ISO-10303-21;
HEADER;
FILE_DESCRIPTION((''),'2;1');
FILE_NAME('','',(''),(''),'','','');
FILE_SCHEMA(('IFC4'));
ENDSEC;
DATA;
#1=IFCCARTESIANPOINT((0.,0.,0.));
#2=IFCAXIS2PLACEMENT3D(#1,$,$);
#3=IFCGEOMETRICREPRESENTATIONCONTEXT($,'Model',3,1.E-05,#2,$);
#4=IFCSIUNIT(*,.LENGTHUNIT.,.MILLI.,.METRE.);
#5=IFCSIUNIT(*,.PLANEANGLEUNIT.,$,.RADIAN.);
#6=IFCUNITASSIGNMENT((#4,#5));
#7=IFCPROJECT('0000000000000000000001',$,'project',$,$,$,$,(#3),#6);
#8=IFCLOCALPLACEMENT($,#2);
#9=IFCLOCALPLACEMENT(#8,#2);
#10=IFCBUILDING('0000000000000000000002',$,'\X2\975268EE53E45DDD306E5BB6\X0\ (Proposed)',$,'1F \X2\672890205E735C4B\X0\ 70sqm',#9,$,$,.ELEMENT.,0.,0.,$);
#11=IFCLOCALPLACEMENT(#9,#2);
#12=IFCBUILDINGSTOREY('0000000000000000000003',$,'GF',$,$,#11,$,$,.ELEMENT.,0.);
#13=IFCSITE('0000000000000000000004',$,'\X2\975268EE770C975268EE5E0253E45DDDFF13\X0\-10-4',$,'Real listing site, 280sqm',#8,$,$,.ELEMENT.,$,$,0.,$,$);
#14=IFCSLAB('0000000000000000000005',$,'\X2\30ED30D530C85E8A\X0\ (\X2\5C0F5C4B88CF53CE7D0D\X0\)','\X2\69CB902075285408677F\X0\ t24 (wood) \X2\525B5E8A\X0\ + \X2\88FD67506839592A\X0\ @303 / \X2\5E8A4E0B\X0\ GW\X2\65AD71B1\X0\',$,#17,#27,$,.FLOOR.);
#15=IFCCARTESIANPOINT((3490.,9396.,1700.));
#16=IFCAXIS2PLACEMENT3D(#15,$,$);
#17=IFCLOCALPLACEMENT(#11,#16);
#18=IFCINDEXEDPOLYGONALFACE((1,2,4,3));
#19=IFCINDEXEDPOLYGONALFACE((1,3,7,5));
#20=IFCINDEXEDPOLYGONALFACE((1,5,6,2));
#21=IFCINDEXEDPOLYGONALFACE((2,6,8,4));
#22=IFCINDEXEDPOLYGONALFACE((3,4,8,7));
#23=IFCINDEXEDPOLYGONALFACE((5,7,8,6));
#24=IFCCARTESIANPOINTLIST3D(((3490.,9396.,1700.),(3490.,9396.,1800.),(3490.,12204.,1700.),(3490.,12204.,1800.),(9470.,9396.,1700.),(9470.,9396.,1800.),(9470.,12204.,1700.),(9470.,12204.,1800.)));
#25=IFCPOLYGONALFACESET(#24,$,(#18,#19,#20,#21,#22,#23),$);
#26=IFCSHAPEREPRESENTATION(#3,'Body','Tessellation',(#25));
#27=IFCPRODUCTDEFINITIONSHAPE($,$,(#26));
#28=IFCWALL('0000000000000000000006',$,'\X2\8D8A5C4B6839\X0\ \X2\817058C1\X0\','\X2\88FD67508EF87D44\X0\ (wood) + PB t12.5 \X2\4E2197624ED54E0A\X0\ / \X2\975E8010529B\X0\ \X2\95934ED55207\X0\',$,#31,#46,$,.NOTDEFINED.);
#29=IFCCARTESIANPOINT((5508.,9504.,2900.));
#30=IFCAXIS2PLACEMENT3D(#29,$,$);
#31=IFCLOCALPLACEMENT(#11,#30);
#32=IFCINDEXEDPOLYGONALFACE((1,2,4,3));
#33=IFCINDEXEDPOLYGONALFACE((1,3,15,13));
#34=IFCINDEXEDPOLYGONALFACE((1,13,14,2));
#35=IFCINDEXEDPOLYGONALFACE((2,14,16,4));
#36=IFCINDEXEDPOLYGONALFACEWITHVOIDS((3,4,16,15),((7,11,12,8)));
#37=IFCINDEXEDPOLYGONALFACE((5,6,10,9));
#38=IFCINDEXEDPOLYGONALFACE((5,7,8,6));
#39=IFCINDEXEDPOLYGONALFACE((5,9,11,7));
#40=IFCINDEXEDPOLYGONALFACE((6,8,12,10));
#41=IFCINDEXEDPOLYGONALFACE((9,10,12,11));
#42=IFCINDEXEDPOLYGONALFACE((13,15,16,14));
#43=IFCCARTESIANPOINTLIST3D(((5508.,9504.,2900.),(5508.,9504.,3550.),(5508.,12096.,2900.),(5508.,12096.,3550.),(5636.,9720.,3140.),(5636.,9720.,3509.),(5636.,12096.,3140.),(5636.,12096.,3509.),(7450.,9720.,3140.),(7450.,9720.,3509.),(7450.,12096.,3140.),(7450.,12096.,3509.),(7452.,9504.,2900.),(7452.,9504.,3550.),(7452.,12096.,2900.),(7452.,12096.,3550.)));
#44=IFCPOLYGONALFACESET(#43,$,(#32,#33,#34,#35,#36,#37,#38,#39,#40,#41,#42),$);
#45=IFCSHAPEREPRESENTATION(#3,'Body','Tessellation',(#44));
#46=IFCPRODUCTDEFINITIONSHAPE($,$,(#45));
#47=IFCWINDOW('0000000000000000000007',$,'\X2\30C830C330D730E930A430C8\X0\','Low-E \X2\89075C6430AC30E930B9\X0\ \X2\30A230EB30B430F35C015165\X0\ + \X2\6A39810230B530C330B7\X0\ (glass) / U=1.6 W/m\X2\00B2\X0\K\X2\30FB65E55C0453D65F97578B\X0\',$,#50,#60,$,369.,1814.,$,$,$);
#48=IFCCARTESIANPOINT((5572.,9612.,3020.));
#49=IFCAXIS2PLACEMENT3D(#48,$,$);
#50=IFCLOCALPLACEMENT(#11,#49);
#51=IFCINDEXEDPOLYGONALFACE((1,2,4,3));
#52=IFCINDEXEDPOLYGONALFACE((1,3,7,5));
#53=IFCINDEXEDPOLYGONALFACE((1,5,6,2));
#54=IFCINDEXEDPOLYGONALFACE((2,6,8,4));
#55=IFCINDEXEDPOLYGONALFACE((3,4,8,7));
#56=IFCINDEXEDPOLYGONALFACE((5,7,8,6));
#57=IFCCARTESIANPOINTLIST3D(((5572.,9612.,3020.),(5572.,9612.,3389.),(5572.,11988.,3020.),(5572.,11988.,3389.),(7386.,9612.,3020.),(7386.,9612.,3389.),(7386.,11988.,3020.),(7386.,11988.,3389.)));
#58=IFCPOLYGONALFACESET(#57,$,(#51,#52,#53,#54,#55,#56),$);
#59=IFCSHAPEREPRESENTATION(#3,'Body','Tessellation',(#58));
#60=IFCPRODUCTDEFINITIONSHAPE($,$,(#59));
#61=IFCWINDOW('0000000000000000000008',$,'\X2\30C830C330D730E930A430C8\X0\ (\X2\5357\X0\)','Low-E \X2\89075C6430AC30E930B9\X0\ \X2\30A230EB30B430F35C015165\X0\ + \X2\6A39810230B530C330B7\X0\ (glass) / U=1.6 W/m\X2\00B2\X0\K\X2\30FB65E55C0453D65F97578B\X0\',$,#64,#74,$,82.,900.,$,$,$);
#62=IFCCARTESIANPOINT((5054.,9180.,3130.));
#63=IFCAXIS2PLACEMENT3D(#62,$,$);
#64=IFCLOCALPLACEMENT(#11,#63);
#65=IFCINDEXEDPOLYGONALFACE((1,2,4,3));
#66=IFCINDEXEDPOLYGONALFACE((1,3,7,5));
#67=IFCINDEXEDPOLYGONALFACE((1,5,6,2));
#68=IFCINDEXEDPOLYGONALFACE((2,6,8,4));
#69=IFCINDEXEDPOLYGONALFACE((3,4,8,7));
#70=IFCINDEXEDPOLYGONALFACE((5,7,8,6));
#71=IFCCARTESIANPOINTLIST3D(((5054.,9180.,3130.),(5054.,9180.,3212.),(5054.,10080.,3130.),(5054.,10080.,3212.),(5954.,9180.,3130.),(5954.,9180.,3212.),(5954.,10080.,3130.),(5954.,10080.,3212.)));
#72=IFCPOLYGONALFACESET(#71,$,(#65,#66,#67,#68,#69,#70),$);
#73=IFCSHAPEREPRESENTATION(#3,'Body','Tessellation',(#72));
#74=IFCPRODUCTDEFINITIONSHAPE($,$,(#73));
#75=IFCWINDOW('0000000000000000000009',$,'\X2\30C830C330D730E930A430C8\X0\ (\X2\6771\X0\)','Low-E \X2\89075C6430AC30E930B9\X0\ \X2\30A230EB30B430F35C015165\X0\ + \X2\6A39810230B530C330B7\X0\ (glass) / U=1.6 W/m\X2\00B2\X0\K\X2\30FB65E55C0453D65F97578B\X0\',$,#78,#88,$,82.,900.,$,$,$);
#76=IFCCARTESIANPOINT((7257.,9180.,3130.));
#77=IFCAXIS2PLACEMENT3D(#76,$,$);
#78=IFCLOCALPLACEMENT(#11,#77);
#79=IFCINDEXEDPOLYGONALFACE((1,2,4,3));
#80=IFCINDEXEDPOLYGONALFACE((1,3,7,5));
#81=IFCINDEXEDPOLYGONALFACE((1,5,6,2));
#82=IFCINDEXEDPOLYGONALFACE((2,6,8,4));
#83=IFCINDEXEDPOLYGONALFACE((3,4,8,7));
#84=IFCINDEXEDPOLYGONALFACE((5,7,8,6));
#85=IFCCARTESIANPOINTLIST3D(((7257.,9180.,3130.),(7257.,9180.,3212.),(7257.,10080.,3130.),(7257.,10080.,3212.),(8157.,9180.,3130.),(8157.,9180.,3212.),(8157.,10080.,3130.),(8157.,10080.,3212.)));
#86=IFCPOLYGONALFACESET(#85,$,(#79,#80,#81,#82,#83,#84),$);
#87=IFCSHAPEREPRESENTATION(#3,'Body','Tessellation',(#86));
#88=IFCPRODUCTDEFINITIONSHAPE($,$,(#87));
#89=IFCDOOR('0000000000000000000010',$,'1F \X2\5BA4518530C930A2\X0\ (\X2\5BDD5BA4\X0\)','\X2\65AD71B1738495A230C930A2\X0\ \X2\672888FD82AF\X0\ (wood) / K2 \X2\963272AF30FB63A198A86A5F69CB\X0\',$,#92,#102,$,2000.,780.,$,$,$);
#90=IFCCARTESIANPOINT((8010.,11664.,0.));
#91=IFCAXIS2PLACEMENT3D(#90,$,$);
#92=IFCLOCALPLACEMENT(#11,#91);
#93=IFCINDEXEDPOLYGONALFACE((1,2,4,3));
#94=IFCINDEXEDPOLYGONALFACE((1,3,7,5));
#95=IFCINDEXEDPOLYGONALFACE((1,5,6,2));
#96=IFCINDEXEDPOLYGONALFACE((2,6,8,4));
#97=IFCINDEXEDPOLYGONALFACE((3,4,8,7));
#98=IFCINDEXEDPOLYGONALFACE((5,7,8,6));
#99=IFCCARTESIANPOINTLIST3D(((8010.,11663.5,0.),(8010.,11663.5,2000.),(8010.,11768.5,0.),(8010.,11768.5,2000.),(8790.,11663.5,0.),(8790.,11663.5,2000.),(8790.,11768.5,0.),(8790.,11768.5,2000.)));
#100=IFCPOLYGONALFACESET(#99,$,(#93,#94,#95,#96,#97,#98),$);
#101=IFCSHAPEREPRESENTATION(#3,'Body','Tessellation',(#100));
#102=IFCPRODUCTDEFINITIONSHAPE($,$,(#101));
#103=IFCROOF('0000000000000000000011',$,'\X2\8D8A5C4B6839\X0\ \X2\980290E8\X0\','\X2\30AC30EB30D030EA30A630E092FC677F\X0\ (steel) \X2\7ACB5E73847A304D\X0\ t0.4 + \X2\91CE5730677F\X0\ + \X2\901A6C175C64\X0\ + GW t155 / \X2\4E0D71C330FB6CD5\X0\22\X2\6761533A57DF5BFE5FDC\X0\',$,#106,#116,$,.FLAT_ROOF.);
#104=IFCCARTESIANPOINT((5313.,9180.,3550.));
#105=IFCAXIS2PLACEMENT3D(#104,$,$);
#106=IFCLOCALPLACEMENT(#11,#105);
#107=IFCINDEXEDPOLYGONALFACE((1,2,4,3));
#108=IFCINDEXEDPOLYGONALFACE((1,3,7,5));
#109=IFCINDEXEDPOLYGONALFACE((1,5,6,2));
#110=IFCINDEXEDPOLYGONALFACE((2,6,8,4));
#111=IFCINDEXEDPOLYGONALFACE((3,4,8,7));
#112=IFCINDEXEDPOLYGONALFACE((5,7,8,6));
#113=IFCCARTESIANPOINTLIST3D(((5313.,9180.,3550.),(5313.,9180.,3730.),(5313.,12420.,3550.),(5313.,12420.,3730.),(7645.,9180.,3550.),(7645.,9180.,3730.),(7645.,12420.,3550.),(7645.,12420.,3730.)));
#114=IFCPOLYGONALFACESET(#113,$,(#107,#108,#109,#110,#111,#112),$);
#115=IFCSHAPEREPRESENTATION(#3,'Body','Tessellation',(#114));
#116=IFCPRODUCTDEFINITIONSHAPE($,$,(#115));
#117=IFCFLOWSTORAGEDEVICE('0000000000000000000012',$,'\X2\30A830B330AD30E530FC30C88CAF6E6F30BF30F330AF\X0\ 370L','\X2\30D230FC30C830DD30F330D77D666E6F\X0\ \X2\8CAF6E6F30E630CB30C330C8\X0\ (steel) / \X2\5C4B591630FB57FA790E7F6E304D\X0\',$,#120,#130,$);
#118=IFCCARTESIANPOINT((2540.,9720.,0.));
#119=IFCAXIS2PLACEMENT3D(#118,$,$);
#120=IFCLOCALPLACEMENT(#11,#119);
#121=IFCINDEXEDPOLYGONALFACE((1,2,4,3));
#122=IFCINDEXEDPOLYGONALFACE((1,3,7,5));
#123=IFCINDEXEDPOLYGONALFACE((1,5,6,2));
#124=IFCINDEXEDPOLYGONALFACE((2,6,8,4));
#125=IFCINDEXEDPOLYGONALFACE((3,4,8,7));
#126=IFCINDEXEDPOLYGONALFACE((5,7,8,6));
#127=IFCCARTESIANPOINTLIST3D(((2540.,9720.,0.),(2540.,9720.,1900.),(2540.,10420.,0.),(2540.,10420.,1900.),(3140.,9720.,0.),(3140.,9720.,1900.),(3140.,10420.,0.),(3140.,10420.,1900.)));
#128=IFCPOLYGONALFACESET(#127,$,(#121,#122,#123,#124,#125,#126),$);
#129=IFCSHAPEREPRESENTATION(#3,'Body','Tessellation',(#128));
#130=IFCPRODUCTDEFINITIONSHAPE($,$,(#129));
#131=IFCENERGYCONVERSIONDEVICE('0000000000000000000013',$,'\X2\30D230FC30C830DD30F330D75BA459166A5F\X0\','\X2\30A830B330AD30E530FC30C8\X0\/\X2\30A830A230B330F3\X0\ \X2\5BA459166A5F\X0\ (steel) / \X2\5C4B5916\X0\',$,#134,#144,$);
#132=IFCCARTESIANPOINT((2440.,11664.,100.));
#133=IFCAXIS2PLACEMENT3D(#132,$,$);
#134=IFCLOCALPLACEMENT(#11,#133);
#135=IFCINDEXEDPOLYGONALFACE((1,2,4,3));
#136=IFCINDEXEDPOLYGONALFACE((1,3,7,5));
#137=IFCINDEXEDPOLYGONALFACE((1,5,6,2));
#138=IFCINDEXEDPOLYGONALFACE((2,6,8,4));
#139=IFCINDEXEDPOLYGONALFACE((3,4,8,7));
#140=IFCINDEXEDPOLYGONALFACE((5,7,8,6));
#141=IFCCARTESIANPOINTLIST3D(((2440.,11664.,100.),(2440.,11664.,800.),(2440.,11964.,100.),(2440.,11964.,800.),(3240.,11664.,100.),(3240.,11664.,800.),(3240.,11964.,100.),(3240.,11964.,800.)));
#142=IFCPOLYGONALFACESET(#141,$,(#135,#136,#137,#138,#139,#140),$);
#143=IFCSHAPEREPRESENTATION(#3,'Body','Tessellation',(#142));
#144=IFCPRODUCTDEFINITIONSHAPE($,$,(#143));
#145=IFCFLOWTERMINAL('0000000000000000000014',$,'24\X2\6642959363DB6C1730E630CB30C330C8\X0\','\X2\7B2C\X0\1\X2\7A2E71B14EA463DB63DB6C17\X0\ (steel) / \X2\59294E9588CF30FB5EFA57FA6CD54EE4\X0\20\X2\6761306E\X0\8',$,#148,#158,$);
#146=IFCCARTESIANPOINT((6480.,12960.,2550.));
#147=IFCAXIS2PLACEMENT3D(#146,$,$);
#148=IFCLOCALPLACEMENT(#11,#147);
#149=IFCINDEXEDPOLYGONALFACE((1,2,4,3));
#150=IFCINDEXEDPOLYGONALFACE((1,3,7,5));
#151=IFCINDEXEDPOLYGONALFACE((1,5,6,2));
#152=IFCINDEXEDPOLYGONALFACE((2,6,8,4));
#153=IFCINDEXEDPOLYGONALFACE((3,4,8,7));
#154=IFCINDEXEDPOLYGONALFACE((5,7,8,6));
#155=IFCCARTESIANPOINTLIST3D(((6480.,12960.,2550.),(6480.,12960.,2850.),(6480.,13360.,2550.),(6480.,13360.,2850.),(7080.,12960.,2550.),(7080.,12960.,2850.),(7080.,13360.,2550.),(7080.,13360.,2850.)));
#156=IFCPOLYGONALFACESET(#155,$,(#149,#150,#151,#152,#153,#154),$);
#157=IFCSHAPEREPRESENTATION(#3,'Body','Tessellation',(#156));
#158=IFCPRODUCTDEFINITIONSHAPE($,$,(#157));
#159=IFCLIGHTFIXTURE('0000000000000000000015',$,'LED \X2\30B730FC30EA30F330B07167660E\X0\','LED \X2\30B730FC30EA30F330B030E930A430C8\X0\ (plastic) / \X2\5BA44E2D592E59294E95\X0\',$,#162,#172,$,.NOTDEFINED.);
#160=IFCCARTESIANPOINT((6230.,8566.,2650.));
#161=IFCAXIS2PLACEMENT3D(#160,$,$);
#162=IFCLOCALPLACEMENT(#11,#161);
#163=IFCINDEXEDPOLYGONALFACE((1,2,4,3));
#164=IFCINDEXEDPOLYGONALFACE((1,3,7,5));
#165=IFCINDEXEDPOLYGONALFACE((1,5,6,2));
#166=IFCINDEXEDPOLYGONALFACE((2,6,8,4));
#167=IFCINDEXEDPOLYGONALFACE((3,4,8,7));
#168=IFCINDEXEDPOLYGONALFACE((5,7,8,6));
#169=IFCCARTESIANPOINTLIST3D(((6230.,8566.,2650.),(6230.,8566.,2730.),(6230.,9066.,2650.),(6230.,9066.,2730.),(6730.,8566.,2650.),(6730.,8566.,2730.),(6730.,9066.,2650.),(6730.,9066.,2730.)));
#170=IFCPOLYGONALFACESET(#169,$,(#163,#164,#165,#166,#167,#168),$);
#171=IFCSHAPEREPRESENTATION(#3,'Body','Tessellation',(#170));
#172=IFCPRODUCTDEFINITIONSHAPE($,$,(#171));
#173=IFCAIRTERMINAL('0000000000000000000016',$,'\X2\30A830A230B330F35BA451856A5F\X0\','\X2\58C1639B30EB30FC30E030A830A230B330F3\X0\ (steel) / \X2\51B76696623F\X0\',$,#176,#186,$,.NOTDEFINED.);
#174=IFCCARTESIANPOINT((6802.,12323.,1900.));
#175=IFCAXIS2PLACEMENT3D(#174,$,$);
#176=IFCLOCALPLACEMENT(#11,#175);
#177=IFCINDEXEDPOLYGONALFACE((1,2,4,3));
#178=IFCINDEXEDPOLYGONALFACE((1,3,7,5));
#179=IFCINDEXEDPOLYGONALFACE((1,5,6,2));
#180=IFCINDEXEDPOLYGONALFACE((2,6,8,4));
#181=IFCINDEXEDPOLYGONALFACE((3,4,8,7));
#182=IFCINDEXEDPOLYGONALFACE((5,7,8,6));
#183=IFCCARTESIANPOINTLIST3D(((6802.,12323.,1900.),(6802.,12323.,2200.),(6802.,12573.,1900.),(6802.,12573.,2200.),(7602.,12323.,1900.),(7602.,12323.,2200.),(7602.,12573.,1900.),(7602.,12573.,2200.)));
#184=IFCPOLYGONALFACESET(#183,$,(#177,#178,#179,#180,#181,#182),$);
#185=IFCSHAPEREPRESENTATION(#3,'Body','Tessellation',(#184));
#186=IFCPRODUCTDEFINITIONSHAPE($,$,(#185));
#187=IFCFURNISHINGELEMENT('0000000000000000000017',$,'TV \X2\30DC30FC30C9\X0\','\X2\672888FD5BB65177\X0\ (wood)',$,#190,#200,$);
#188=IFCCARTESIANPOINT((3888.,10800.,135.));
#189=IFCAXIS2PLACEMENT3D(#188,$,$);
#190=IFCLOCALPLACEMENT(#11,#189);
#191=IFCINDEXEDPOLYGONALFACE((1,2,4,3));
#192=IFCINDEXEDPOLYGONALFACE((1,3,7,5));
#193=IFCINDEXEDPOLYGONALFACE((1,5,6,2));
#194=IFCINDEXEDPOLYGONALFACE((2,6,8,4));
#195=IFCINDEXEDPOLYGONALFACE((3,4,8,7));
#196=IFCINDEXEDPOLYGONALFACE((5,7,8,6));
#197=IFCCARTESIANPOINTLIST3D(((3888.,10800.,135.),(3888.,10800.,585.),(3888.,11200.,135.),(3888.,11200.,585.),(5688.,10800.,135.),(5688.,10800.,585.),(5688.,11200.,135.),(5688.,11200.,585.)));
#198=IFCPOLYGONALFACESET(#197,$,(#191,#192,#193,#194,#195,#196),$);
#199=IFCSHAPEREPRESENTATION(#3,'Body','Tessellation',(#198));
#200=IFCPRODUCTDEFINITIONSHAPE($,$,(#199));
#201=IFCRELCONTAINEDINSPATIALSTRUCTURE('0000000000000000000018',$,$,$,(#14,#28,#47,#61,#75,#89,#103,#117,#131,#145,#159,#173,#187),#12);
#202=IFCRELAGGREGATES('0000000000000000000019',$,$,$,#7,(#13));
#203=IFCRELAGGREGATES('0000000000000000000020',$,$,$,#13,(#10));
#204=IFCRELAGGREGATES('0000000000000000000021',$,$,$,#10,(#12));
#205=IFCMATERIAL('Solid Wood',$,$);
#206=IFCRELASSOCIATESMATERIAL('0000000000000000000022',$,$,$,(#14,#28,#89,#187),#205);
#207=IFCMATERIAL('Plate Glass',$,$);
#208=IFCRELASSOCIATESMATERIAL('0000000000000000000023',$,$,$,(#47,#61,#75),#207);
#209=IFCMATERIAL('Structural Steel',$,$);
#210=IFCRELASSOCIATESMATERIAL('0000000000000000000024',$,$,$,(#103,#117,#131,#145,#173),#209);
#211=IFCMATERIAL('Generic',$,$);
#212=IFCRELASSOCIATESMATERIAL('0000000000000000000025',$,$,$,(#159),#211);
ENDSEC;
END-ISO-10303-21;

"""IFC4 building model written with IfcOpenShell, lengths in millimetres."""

from ifc_helpers import new_model, si_unit, frame, frame_2d, origin, place, context, project, spatial, rectangle, extrude, material, element, fill, save


model = new_model("IFC4")

# Units and contexts
model_context = context("Model", 3, precision=1e-05, world=origin())
ifc_project = project(units=[si_unit("LENGTHUNIT", "METRE", prefix="MILLI"), si_unit("PLANEANGLEUNIT", "RADIAN")], contexts=[model_context])

# Site, building, storey
site_placement = place(None, origin())
site = spatial("IfcSite", under=ifc_project, at=site_placement, Name="青森県青森市古川３-10-4", ObjectType="Real listing site, 280sqm", CompositionType="ELEMENT", RefElevation=0.0)
building_placement = place(site_placement, origin())
building = spatial("IfcBuilding", under=site, at=building_placement, Name="青森古川の家 (Proposed)", ObjectType="1F 木造平屋 70sqm", CompositionType="ELEMENT", ElevationOfRefHeight=0.0, ElevationOfTerrain=0.0)
storey_placement = place(building_placement, origin())
storey = spatial("IfcBuildingStorey", under=building, at=storey_placement, Name="GF", CompositionType="ELEMENT", Elevation=0.0)

# Shared definitions
ifc_material_1 = material(Name="Solid Wood")

# Slab
slab_placement = place(storey_placement, frame((3490.0, 9396.0, 1700.0)))
element("IfcSlab", 1, at=slab_placement, inside=storey, material=ifc_material_1, Name="ロフト床 (小屋裏収納)", Description="構造用合板 t24 (wood) 剛床 + 製材根太 @303 / 床下 GW断熱", PredefinedType="FLOOR", context=model_context, shape_type="SweptSolid", body=[
    extrude(rectangle(XDim=5980.0, YDim=2808.0, at=frame_2d((2990.0, 1404.0))), frame((3490.0, 9396.0, 1700.0)), (0.0, 0.0, 1.0), 100.0),
])

# Wall, openings, windows
wall_1_placement = place(storey_placement, frame((5508.0, 9504.0, 2900.0)))
wall_1 = element("IfcWall", 2, at=wall_1_placement, inside=storey, material=ifc_material_1, Name="越屋根 腰壁", Description="製材軸組 (wood) + PB t12.5 両面仕上 / 非耐力 間仕切", PredefinedType="NOTDEFINED", context=model_context, shape_type="SweptSolid", body=[
    extrude(rectangle(XDim=1944.0, YDim=2592.0, at=frame_2d((972.0, 1296.0))), frame((5508.0, 9504.0, 2900.0)), (0.0, 0.0, 1.0), 650.0),
])
opening_1_placement = place(storey_placement, frame((5572.0, 9612.0, 3020.0)))
opening_1 = element("IfcOpeningElement", 3, at=opening_1_placement, cuts=wall_1, PredefinedType="NOTDEFINED", context=model_context, shape_type="SweptSolid", body=[
    extrude(rectangle(XDim=1814.0, YDim=2376.0, at=frame_2d((907.0, 1188.0))), frame((5572.0, 9612.0, 3020.0)), (0.0, 0.0, 1.0), 369.0),
])
opening_2_placement = place(storey_placement, frame((5054.0, 9180.0, 3130.0)))
opening_2 = element("IfcOpeningElement", 4, at=opening_2_placement, cuts=wall_1, PredefinedType="NOTDEFINED", context=model_context, shape_type="SweptSolid", body=[
    extrude(rectangle(XDim=900.0, YDim=900.0, at=frame_2d((450.0, 450.0))), frame((5054.0, 9180.0, 3130.0)), (0.0, 0.0, 1.0), 82.0),
])
opening_3_placement = place(storey_placement, frame((7257.0, 9180.0, 3130.0)))
opening_3 = element("IfcOpeningElement", 5, at=opening_3_placement, cuts=wall_1, PredefinedType="NOTDEFINED", context=model_context, shape_type="SweptSolid", body=[
    extrude(rectangle(XDim=900.0, YDim=900.0, at=frame_2d((450.0, 450.0))), frame((7257.0, 9180.0, 3130.0)), (0.0, 0.0, 1.0), 82.0),
])
ifc_material_2 = material(Name="Plate Glass")
window_1_placement = place(storey_placement, frame((5572.0, 9612.0, 3020.0)))
window_1 = element("IfcWindow", 6, at=window_1_placement, inside=storey, material=ifc_material_2, Name="トップライト", Description="Low-E 複層ガラス アルゴン封入 + 樹脂サッシ (glass) / U=1.6 W/m²K・日射取得型", OverallHeight=369.0, OverallWidth=1814.0, context=model_context, shape_type="SweptSolid", body=[
    extrude(rectangle(XDim=1814.0, YDim=2376.0, at=frame_2d((907.0, 1188.0))), frame((5572.0, 9612.0, 3020.0)), (0.0, 0.0, 1.0), 369.0),
])
fill(opening_1, window_1)
window_2_placement = place(storey_placement, frame((5054.0, 9180.0, 3130.0)))
window_2 = element("IfcWindow", 7, at=window_2_placement, inside=storey, material=ifc_material_2, Name="トップライト (南)", Description="Low-E 複層ガラス アルゴン封入 + 樹脂サッシ (glass) / U=1.6 W/m²K・日射取得型", OverallHeight=82.0, OverallWidth=900.0, context=model_context, shape_type="SweptSolid", body=[
    extrude(rectangle(XDim=900.0, YDim=900.0, at=frame_2d((450.0, 450.0))), frame((5054.0, 9180.0, 3130.0)), (0.0, 0.0, 1.0), 82.0),
])
fill(opening_2, window_2)
window_3_placement = place(storey_placement, frame((7257.0, 9180.0, 3130.0)))
window_3 = element("IfcWindow", 8, at=window_3_placement, inside=storey, material=ifc_material_2, Name="トップライト (東)", Description="Low-E 複層ガラス アルゴン封入 + 樹脂サッシ (glass) / U=1.6 W/m²K・日射取得型", OverallHeight=82.0, OverallWidth=900.0, context=model_context, shape_type="SweptSolid", body=[
    extrude(rectangle(XDim=900.0, YDim=900.0, at=frame_2d((450.0, 450.0))), frame((7257.0, 9180.0, 3130.0)), (0.0, 0.0, 1.0), 82.0),
])
fill(opening_3, window_3)

# Door
door_1_placement = place(storey_placement, frame((8010.0, 11664.0, 0.0)))
element("IfcDoor", 9, at=door_1_placement, inside=storey, material=ifc_material_1, Name="1F 室内ドア (寝室)", Description="断熱玄関ドア 木製芯 (wood) / K2 防犯・採風機構", OverallHeight=2000.0, OverallWidth=780.0, context=model_context, shape_type="SweptSolid", body=[
    extrude(rectangle(XDim=780.0, YDim=105.0, at=frame_2d((390.0, 52.0))), frame((8010.0, 11664.0, 0.0)), (0.0, 0.0, 1.0), 2000.0),
])

# Roof
ifc_material_3 = material(Name="Structural Steel")
roof_placement = place(storey_placement, frame((5313.0, 9180.0, 3550.0)))
element("IfcRoof", 10, at=roof_placement, inside=storey, material=ifc_material_3, Name="越屋根 頂部", Description="ガルバリウム鋼板 (steel) 立平葺き t0.4 + 野地板 + 通気層 + GW t155 / 不燃・法22条区域対応", PredefinedType="FLAT_ROOF", context=model_context, shape_type="SweptSolid", body=[
    extrude(rectangle(XDim=2332.0, YDim=3240.0, at=frame_2d((1166.0, 1620.0))), frame((5313.0, 9180.0, 3550.0)), (0.0, 0.0, 1.0), 180.0),
])

# Flow storage device
flow_storage_device_placement = place(storey_placement, frame((2540.0, 9720.0, 0.0)))
element("IfcFlowStorageDevice", 11, at=flow_storage_device_placement, inside=storey, material=ifc_material_3, Name="エコキュート貯湯タンク 370L", Description="ヒートポンプ給湯 貯湯ユニット (steel) / 屋外・基礎置き", context=model_context, shape_type="SweptSolid", body=[
    extrude(rectangle(XDim=600.0, YDim=700.0, at=frame_2d((300.0, 350.0))), frame((2540.0, 9720.0, 0.0)), (0.0, 0.0, 1.0), 1900.0),
])

# Energy conversion device
energy_conversion_device_placement = place(storey_placement, frame((2440.0, 11664.0, 100.0)))
element("IfcEnergyConversionDevice", 12, at=energy_conversion_device_placement, inside=storey, material=ifc_material_3, Name="ヒートポンプ室外機", Description="エコキュート/エアコン 室外機 (steel) / 屋外", context=model_context, shape_type="SweptSolid", body=[
    extrude(rectangle(XDim=800.0, YDim=300.0, at=frame_2d((400.0, 150.0))), frame((2440.0, 11664.0, 100.0)), (0.0, 0.0, 1.0), 700.0),
])

# Flow terminal
flow_terminal_placement = place(storey_placement, frame((6480.0, 12960.0, 2550.0)))
element("IfcFlowTerminal", 13, at=flow_terminal_placement, inside=storey, material=ifc_material_3, Name="24時間換気ユニット", Description="第1種熱交換換気 (steel) / 天井裏・建基法令20条の8", context=model_context, shape_type="SweptSolid", body=[
    extrude(rectangle(XDim=600.0, YDim=400.0, at=frame_2d((300.0, 200.0))), frame((6480.0, 12960.0, 2550.0)), (0.0, 0.0, 1.0), 300.0),
])

# Light fixture
ifc_material_4 = material(Name="Generic")
light_fixture_placement = place(storey_placement, frame((6230.0, 8566.0, 2650.0)))
element("IfcLightFixture", 14, at=light_fixture_placement, inside=storey, material=ifc_material_4, Name="LED シーリング照明", Description="LED シーリングライト (plastic) / 室中央天井", PredefinedType="NOTDEFINED", context=model_context, shape_type="SweptSolid", body=[
    extrude(rectangle(XDim=500.0, YDim=500.0, at=frame_2d((250.0, 250.0))), frame((6230.0, 8566.0, 2650.0)), (0.0, 0.0, 1.0), 80.0),
])

# Air terminal
air_terminal_placement = place(storey_placement, frame((6802.0, 12323.0, 1900.0)))
element("IfcAirTerminal", 15, at=air_terminal_placement, inside=storey, material=ifc_material_3, Name="エアコン室内機", Description="壁掛ルームエアコン (steel) / 冷暖房", PredefinedType="NOTDEFINED", context=model_context, shape_type="SweptSolid", body=[
    extrude(rectangle(XDim=800.0, YDim=250.0, at=frame_2d((400.0, 125.0))), frame((6802.0, 12323.0, 1900.0)), (0.0, 0.0, 1.0), 300.0),
])

# Furnishing element
furnishing_placement = place(storey_placement, frame((3888.0, 10800.0, 135.0)))
element("IfcFurnishingElement", 16, at=furnishing_placement, inside=storey, material=ifc_material_1, Name="TV ボード", Description="木製家具 (wood)", context=model_context, shape_type="SweptSolid", body=[
    extrude(rectangle(XDim=1800.0, YDim=400.0, at=frame_2d((900.0, 200.0))), frame((3888.0, 10800.0, 135.0)), (0.0, 0.0, 1.0), 450.0),
])

save(model, "model.ifc")
